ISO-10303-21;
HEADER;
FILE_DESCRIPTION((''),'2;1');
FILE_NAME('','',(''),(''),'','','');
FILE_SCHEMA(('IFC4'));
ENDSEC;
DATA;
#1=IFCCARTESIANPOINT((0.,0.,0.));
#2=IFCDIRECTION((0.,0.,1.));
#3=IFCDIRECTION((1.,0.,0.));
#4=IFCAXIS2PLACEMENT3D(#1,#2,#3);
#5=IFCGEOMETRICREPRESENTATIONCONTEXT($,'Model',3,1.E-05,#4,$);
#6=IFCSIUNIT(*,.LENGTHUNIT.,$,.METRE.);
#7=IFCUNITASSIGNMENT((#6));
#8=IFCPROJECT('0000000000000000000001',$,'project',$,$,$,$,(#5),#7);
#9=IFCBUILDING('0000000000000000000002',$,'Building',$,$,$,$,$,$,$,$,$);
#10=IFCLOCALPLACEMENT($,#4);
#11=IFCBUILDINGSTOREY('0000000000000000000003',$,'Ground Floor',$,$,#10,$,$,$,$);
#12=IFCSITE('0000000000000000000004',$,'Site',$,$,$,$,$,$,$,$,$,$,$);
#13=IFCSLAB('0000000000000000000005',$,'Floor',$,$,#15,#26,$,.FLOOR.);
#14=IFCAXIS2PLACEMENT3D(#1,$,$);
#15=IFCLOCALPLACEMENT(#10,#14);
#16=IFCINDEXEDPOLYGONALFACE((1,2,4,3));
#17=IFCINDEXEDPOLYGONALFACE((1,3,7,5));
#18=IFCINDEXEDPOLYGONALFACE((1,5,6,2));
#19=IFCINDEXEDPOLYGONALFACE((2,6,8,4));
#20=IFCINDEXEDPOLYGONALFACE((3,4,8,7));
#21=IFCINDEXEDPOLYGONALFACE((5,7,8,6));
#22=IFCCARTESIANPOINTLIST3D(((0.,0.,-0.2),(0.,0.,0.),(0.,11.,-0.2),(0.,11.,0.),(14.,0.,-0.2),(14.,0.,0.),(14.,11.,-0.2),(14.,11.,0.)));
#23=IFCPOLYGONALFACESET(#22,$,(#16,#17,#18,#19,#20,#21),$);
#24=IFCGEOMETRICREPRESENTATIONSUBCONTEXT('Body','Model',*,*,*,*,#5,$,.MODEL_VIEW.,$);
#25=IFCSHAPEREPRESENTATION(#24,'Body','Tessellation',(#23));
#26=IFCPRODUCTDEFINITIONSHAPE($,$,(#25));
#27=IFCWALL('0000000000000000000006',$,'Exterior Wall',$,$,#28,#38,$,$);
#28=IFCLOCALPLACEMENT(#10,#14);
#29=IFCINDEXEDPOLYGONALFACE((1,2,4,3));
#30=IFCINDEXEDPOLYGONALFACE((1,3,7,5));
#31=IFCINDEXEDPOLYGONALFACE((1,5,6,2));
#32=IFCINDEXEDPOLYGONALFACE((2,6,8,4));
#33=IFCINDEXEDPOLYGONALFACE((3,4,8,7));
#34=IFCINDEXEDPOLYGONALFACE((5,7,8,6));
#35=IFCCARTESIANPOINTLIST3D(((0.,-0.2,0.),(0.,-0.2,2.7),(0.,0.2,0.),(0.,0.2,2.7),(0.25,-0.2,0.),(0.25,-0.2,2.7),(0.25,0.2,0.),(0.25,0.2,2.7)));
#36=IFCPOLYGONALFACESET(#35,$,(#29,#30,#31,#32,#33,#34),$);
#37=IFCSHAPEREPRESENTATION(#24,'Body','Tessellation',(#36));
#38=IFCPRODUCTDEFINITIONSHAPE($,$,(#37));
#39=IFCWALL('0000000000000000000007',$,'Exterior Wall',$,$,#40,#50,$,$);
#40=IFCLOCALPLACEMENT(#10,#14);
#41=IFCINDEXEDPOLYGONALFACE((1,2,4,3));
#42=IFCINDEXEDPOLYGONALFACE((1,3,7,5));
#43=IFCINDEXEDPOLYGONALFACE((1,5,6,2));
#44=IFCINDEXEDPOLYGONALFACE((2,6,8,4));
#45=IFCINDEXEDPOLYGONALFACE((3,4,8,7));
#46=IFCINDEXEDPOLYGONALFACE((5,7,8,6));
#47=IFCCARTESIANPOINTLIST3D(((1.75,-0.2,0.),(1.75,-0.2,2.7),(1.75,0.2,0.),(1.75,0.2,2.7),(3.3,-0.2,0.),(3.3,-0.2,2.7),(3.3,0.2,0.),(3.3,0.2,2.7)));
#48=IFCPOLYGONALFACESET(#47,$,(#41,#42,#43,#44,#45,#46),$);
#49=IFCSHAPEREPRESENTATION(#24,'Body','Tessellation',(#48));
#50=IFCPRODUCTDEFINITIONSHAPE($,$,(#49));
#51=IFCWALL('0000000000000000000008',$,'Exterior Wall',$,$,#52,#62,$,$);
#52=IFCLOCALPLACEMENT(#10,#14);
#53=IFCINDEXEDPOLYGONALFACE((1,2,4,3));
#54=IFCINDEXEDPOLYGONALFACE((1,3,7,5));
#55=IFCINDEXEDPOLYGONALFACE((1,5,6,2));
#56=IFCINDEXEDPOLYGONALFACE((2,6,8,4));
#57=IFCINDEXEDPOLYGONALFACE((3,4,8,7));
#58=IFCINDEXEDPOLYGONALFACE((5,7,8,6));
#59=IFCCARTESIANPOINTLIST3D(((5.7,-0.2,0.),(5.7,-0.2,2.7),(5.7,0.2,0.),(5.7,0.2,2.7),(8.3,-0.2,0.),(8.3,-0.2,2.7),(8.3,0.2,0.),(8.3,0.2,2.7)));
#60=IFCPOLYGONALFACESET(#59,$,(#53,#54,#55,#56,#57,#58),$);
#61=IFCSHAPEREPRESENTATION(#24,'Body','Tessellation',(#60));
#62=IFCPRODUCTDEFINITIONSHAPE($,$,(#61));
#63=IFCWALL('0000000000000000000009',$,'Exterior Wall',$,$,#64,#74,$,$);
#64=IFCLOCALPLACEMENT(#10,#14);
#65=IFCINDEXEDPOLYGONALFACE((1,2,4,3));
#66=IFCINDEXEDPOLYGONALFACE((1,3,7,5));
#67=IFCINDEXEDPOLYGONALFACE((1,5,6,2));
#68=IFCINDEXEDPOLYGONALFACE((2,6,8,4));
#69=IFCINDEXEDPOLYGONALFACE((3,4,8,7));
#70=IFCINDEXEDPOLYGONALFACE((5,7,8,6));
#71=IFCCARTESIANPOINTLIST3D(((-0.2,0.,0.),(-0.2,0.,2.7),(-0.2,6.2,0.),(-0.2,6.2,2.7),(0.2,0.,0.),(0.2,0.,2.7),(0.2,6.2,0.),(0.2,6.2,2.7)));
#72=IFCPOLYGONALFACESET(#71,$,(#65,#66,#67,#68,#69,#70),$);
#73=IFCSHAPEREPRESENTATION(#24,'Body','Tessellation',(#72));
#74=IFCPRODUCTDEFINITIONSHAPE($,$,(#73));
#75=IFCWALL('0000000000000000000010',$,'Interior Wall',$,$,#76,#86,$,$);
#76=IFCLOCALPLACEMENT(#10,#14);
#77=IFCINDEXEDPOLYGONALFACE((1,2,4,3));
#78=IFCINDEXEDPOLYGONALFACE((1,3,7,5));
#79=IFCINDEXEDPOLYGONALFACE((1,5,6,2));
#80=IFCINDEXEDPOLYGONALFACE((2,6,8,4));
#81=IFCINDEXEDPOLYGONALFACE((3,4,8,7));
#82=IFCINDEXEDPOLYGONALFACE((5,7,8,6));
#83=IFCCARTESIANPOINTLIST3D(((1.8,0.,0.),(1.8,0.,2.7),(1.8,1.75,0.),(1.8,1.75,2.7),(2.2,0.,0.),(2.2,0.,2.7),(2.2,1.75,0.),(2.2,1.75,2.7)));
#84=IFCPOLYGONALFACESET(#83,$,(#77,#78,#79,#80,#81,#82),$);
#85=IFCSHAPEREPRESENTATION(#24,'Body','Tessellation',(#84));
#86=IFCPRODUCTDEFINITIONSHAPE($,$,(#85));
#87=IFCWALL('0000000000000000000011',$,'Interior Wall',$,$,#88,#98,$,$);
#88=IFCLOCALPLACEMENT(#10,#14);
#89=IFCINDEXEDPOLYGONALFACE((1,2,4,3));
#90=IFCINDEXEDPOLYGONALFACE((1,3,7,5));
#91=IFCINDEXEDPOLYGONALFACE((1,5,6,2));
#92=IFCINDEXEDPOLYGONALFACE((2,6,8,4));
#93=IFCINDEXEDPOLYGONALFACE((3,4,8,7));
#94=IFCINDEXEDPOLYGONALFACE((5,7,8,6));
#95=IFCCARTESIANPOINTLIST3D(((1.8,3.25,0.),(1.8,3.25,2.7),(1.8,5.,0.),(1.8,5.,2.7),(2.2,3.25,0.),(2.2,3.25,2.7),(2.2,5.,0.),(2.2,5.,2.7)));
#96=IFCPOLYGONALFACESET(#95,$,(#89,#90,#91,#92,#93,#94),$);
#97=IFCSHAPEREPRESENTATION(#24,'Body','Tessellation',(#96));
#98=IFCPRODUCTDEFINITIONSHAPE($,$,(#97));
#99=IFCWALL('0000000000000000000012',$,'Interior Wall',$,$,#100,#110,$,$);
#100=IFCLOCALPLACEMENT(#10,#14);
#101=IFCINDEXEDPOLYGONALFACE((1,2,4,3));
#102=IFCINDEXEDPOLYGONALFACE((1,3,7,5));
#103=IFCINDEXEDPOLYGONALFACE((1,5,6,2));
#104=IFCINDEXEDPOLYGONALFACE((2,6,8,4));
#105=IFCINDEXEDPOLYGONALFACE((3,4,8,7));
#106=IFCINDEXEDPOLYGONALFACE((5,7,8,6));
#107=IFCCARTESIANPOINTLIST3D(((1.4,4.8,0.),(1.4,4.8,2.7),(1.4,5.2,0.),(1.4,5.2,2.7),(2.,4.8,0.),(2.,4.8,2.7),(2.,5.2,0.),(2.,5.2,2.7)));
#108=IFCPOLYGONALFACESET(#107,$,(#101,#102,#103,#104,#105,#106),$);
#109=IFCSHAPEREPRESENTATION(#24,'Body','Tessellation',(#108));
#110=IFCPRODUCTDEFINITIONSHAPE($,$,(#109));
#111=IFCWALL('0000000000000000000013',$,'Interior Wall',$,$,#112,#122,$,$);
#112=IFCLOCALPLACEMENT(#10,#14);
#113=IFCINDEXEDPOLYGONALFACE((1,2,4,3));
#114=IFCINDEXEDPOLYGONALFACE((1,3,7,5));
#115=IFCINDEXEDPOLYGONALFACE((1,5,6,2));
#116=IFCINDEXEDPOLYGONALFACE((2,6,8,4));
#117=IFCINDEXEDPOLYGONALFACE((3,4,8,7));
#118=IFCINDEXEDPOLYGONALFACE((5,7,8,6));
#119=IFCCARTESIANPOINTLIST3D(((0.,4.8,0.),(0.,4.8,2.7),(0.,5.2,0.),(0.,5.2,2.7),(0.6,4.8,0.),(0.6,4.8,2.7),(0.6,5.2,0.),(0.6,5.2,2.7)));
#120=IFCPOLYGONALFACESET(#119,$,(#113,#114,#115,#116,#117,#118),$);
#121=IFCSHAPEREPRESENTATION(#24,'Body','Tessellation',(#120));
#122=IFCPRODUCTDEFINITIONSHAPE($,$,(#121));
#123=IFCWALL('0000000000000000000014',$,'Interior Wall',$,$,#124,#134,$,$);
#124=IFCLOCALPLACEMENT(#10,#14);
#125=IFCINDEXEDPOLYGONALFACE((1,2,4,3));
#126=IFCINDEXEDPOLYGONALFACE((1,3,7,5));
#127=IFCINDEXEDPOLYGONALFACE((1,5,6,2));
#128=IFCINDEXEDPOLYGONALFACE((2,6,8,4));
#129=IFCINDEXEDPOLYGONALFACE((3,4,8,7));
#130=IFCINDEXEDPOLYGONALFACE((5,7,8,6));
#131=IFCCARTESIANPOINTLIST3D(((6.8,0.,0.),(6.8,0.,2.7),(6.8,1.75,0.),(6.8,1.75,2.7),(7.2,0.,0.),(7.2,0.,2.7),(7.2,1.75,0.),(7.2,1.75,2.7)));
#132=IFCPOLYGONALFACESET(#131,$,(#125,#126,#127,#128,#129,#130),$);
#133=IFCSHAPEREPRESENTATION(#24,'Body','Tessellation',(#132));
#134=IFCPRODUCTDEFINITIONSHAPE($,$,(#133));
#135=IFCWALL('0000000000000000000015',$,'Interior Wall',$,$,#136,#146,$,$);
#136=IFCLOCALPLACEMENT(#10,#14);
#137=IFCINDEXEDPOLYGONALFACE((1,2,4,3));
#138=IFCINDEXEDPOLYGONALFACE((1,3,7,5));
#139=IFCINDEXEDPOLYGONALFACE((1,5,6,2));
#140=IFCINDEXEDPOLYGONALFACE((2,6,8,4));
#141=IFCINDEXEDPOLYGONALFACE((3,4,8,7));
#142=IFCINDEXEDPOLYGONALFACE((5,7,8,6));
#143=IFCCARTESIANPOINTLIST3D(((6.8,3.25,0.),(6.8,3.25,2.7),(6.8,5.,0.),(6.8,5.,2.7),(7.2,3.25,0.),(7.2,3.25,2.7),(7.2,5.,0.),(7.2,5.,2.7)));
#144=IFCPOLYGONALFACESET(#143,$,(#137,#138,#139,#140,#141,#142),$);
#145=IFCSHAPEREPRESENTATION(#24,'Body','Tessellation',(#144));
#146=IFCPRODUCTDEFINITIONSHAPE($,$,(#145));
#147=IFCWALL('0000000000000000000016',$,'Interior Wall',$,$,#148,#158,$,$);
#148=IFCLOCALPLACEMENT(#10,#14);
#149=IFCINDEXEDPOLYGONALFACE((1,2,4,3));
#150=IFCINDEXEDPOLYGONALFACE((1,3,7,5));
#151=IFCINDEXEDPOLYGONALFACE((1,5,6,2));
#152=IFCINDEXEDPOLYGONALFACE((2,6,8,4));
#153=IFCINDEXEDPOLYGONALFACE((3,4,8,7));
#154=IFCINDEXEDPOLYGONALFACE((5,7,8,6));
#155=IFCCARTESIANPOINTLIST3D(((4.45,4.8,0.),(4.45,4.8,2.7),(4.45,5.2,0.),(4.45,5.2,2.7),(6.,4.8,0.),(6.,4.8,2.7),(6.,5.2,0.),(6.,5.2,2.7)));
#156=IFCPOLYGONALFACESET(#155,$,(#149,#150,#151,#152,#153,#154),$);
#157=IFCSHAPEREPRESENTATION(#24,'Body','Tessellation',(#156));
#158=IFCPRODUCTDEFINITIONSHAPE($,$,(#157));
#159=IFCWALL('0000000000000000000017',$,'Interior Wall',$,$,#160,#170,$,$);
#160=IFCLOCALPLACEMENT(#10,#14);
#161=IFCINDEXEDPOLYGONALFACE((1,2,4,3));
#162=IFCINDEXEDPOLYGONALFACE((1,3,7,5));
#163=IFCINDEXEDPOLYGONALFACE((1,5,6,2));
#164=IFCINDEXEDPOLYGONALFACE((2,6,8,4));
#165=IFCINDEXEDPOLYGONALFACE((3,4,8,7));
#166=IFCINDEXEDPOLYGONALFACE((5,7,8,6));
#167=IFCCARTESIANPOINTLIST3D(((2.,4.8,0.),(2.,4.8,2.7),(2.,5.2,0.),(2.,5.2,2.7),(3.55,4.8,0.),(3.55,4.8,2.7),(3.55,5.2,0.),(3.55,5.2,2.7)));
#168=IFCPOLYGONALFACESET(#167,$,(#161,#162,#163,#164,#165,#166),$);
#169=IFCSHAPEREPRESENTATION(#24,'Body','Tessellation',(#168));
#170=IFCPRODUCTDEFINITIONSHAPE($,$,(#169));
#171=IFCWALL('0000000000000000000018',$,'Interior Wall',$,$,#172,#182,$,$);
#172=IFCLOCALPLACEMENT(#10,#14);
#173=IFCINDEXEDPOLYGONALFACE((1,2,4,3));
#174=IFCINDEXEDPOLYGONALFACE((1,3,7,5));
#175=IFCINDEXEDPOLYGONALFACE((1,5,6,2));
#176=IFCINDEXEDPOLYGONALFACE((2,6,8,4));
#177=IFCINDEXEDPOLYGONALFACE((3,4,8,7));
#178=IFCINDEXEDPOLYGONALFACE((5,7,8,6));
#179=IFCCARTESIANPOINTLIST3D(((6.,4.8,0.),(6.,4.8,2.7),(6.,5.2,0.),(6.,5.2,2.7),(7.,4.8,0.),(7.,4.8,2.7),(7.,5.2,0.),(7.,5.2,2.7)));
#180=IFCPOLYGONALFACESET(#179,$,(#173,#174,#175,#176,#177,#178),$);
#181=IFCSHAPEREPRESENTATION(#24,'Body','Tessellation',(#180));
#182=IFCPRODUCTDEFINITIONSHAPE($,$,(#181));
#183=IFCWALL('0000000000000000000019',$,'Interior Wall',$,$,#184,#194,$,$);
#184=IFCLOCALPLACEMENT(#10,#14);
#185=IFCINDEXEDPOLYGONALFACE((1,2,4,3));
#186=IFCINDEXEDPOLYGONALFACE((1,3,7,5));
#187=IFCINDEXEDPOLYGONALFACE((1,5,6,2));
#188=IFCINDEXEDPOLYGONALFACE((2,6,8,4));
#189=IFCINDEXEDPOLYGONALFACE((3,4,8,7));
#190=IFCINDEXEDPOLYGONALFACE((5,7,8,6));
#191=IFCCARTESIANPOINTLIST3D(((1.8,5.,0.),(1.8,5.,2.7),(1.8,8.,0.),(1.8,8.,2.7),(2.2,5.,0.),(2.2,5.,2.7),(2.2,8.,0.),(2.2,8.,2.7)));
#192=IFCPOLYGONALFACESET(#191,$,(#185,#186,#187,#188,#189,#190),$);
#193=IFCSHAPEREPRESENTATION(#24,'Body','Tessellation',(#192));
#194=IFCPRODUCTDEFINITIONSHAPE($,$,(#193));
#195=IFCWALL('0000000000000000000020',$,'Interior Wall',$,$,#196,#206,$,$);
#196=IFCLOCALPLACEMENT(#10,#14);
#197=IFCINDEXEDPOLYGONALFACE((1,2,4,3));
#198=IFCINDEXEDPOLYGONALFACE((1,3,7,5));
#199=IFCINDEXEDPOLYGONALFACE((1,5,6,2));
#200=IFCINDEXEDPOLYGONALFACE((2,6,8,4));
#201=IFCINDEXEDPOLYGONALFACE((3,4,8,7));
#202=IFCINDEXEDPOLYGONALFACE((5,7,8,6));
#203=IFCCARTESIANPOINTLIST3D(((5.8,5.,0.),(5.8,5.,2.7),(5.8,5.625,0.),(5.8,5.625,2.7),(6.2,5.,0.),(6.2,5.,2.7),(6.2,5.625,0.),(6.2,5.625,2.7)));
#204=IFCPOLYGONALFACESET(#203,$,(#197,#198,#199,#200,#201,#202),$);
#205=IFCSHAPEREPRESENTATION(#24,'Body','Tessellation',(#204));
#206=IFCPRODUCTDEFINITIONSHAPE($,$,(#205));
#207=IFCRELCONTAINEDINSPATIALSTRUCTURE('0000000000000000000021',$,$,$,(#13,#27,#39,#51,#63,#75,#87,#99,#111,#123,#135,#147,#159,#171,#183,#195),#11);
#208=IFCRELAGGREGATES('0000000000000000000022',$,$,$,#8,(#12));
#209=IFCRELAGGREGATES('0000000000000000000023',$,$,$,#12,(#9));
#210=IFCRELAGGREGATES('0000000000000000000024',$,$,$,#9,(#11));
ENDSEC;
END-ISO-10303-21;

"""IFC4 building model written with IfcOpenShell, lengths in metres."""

from ifc_helpers import new_model, si_unit, frame, origin_with_axes, place, context, subcontext, project, spatial, indexed_curve, outline, extrude, element, save


model = new_model("IFC4")

# Units and contexts
model_context = context("Model", 3, precision=1e-05, world=origin_with_axes())
body_context = subcontext(model_context, "Body", "Model", "MODEL_VIEW")
ifc_project = project(units=[si_unit("LENGTHUNIT", "METRE")], contexts=[model_context])

# Site, building, storey
site = spatial("IfcSite", under=ifc_project, Name="Site")
building = spatial("IfcBuilding", under=site, Name="Building")
storey_placement = place(None, origin_with_axes())
storey = spatial("IfcBuildingStorey", under=building, at=storey_placement, Name="Ground Floor")

# Slab
slab_placement = place(storey_placement, frame((0.0, 0.0, -0.2), z_axis=(0.0, 0.0, 1.0), x_axis=(1.0, 0.0, 0.0)))
element("IfcSlab", 1, at=slab_placement, inside=storey, Name="Floor", PredefinedType="FLOOR", context=body_context, shape_type="SweptSolid", body=[
    extrude(outline(indexed_curve([(0.0, 0.0), (14.0, 0.0), (14.0, 11.0), (0.0, 11.0)])), None, (0.0, 0.0, 1.0), 0.2),
])

# Walls
wall_1_placement = place(storey_placement, origin_with_axes())
element("IfcWall", 2, at=wall_1_placement, inside=storey, Name="Exterior Wall", context=body_context, shape_type="SweptSolid", body=[
    extrude(outline(indexed_curve([(0.0, 0.0), (0.0, 0.4), (0.25, 0.4), (0.25, 0.0), (0.0, 0.0)], self_intersect=False)), frame((0.0, -0.2, 0.0), z_axis=(0.0, 0.0, 1.0), x_axis=(1.0, 0.0, 0.0)), (0.0, 0.0, 1.0), 2.7),
])
wall_2_placement = place(storey_placement, frame((1.75, 0.0, 0.0), z_axis=(0.0, 0.0, 1.0), x_axis=(1.0, 0.0, 0.0)))
element("IfcWall", 3, at=wall_2_placement, inside=storey, Name="Exterior Wall", context=body_context, shape_type="SweptSolid", body=[
    extrude(outline(indexed_curve([(0.0, 0.0), (0.0, 0.4), (1.55, 0.4), (1.55, 0.0), (0.0, 0.0)], self_intersect=False)), frame((0.0, -0.2, 0.0), z_axis=(0.0, 0.0, 1.0), x_axis=(1.0, 0.0, 0.0)), (0.0, 0.0, 1.0), 2.7),
])
wall_3_placement = place(storey_placement, frame((5.7, 0.0, 0.0), z_axis=(0.0, 0.0, 1.0), x_axis=(1.0, 0.0, 0.0)))
element("IfcWall", 4, at=wall_3_placement, inside=storey, Name="Exterior Wall", context=body_context, shape_type="SweptSolid", body=[
    extrude(outline(indexed_curve([(0.0, 0.0), (0.0, 0.4), (2.6, 0.4), (2.6, 0.0), (0.0, 0.0)], self_intersect=False)), frame((0.0, -0.2, 0.0), z_axis=(0.0, 0.0, 1.0), x_axis=(1.0, 0.0, 0.0)), (0.0, 0.0, 1.0), 2.7),
])
wall_4_placement = place(storey_placement, frame((0.0, 6.2, 0.0), z_axis=(0.0, 0.0, 1.0), x_axis=(0.0, -1.0, 0.0)))
element("IfcWall", 5, at=wall_4_placement, inside=storey, Name="Exterior Wall", context=body_context, shape_type="SweptSolid", body=[
    extrude(outline(indexed_curve([(0.0, 0.0), (0.0, 0.4), (6.2, 0.4), (6.2, 0.0), (0.0, 0.0)], self_intersect=False)), frame((0.0, -0.2, 0.0), z_axis=(0.0, 0.0, 1.0), x_axis=(1.0, 0.0, 0.0)), (0.0, 0.0, 1.0), 2.7),
])
for number, where, z_axis, x_axis, name in (
    (6, (2.0, 0.0, 0.0), (0.0, 0.0, 1.0), (0.0, 1.0, 0.0), "Interior Wall"),
    (7, (2.0, 3.25, 0.0), (0.0, 0.0, 1.0), (0.0, 1.0, 0.0), "Interior Wall"),
):
    element("IfcWall", number, at=place(storey_placement, frame(where, z_axis=z_axis, x_axis=x_axis)), inside=storey, Name=name, context=body_context, shape_type="SweptSolid", body=[
        extrude(outline(indexed_curve([(0.0, 0.0), (0.0, 0.4), (1.75, 0.4), (1.75, 0.0), (0.0, 0.0)], self_intersect=False)), frame((0.0, -0.2, 0.0), z_axis=(0.0, 0.0, 1.0), x_axis=(1.0, 0.0, 0.0)), (0.0, 0.0, 1.0), 2.7),
    ])
for number, where, z_axis, x_axis, name in (
    (8, (2.0, 5.0, 0.0), (0.0, 0.0, 1.0), (-1.0, 0.0, 0.0), "Interior Wall"),
    (9, (0.6, 5.0, 0.0), (0.0, 0.0, 1.0), (-1.0, 0.0, 0.0), "Interior Wall"),
):
    element("IfcWall", number, at=place(storey_placement, frame(where, z_axis=z_axis, x_axis=x_axis)), inside=storey, Name=name, context=body_context, shape_type="SweptSolid", body=[
        extrude(outline(indexed_curve([(0.0, 0.0), (0.0, 0.4), (0.6, 0.4), (0.6, 0.0), (0.0, 0.0)], self_intersect=False)), frame((0.0, -0.2, 0.0), z_axis=(0.0, 0.0, 1.0), x_axis=(1.0, 0.0, 0.0)), (0.0, 0.0, 1.0), 2.7),
    ])
for number, where, z_axis, x_axis, name in (
    (10, (7.0, 0.0, 0.0), (0.0, 0.0, 1.0), (0.0, 1.0, 0.0), "Interior Wall"),
    (11, (7.0, 3.25, 0.0), (0.0, 0.0, 1.0), (0.0, 1.0, 0.0), "Interior Wall"),
):
    element("IfcWall", number, at=place(storey_placement, frame(where, z_axis=z_axis, x_axis=x_axis)), inside=storey, Name=name, context=body_context, shape_type="SweptSolid", body=[
        extrude(outline(indexed_curve([(0.0, 0.0), (0.0, 0.4), (1.75, 0.4), (1.75, 0.0), (0.0, 0.0)], self_intersect=False)), frame((0.0, -0.2, 0.0), z_axis=(0.0, 0.0, 1.0), x_axis=(1.0, 0.0, 0.0)), (0.0, 0.0, 1.0), 2.7),
    ])
for number, where, z_axis, x_axis, name in (
    (12, (6.0, 5.0, 0.0), (0.0, 0.0, 1.0), (-1.0, 0.0, 0.0), "Interior Wall"),
    (13, (3.55, 5.0, 0.0), (0.0, 0.0, 1.0), (-1.0, 0.0, 0.0), "Interior Wall"),
):
    element("IfcWall", number, at=place(storey_placement, frame(where, z_axis=z_axis, x_axis=x_axis)), inside=storey, Name=name, context=body_context, shape_type="SweptSolid", body=[
        extrude(outline(indexed_curve([(0.0, 0.0), (0.0, 0.4), (1.55, 0.4), (1.55, 0.0), (0.0, 0.0)], self_intersect=False)), frame((0.0, -0.2, 0.0), z_axis=(0.0, 0.0, 1.0), x_axis=(1.0, 0.0, 0.0)), (0.0, 0.0, 1.0), 2.7),
    ])
wall_5_placement = place(storey_placement, frame((7.0, 5.0, 0.0), z_axis=(0.0, 0.0, 1.0), x_axis=(-1.0, 0.0, 0.0)))
element("IfcWall", 14, at=wall_5_placement, inside=storey, Name="Interior Wall", context=body_context, shape_type="SweptSolid", body=[
    extrude(outline(indexed_curve([(0.0, 0.0), (0.0, 0.4), (1.0, 0.4), (1.0, 0.0), (0.0, 0.0)], self_intersect=False)), frame((0.0, -0.2, 0.0), z_axis=(0.0, 0.0, 1.0), x_axis=(1.0, 0.0, 0.0)), (0.0, 0.0, 1.0), 2.7),
])
wall_6_placement = place(storey_placement, frame((2.0, 5.0, 0.0), z_axis=(0.0, 0.0, 1.0), x_axis=(0.0, 1.0, 0.0)))
element("IfcWall", 15, at=wall_6_placement, inside=storey, Name="Interior Wall", context=body_context, shape_type="SweptSolid", body=[
    extrude(outline(indexed_curve([(0.0, 0.0), (0.0, 0.4), (3.0, 0.4), (3.0, 0.0), (0.0, 0.0)], self_intersect=False)), frame((0.0, -0.2, 0.0), z_axis=(0.0, 0.0, 1.0), x_axis=(1.0, 0.0, 0.0)), (0.0, 0.0, 1.0), 2.7),
])
wall_7_placement = place(storey_placement, frame((6.0, 5.0, 0.0), z_axis=(0.0, 0.0, 1.0), x_axis=(0.0, 1.0, 0.0)))
element("IfcWall", 16, at=wall_7_placement, inside=storey, Name="Interior Wall", context=body_context, shape_type="SweptSolid", body=[
    extrude(outline(indexed_curve([(0.0, 0.0), (0.0, 0.4), (0.625, 0.4), (0.625, 0.0), (0.0, 0.0)], self_intersect=False)), frame((0.0, -0.2, 0.0), z_axis=(0.0, 0.0, 1.0), x_axis=(1.0, 0.0, 0.0)), (0.0, 0.0, 1.0), 2.7),
])

save(model, "model.ifc")
